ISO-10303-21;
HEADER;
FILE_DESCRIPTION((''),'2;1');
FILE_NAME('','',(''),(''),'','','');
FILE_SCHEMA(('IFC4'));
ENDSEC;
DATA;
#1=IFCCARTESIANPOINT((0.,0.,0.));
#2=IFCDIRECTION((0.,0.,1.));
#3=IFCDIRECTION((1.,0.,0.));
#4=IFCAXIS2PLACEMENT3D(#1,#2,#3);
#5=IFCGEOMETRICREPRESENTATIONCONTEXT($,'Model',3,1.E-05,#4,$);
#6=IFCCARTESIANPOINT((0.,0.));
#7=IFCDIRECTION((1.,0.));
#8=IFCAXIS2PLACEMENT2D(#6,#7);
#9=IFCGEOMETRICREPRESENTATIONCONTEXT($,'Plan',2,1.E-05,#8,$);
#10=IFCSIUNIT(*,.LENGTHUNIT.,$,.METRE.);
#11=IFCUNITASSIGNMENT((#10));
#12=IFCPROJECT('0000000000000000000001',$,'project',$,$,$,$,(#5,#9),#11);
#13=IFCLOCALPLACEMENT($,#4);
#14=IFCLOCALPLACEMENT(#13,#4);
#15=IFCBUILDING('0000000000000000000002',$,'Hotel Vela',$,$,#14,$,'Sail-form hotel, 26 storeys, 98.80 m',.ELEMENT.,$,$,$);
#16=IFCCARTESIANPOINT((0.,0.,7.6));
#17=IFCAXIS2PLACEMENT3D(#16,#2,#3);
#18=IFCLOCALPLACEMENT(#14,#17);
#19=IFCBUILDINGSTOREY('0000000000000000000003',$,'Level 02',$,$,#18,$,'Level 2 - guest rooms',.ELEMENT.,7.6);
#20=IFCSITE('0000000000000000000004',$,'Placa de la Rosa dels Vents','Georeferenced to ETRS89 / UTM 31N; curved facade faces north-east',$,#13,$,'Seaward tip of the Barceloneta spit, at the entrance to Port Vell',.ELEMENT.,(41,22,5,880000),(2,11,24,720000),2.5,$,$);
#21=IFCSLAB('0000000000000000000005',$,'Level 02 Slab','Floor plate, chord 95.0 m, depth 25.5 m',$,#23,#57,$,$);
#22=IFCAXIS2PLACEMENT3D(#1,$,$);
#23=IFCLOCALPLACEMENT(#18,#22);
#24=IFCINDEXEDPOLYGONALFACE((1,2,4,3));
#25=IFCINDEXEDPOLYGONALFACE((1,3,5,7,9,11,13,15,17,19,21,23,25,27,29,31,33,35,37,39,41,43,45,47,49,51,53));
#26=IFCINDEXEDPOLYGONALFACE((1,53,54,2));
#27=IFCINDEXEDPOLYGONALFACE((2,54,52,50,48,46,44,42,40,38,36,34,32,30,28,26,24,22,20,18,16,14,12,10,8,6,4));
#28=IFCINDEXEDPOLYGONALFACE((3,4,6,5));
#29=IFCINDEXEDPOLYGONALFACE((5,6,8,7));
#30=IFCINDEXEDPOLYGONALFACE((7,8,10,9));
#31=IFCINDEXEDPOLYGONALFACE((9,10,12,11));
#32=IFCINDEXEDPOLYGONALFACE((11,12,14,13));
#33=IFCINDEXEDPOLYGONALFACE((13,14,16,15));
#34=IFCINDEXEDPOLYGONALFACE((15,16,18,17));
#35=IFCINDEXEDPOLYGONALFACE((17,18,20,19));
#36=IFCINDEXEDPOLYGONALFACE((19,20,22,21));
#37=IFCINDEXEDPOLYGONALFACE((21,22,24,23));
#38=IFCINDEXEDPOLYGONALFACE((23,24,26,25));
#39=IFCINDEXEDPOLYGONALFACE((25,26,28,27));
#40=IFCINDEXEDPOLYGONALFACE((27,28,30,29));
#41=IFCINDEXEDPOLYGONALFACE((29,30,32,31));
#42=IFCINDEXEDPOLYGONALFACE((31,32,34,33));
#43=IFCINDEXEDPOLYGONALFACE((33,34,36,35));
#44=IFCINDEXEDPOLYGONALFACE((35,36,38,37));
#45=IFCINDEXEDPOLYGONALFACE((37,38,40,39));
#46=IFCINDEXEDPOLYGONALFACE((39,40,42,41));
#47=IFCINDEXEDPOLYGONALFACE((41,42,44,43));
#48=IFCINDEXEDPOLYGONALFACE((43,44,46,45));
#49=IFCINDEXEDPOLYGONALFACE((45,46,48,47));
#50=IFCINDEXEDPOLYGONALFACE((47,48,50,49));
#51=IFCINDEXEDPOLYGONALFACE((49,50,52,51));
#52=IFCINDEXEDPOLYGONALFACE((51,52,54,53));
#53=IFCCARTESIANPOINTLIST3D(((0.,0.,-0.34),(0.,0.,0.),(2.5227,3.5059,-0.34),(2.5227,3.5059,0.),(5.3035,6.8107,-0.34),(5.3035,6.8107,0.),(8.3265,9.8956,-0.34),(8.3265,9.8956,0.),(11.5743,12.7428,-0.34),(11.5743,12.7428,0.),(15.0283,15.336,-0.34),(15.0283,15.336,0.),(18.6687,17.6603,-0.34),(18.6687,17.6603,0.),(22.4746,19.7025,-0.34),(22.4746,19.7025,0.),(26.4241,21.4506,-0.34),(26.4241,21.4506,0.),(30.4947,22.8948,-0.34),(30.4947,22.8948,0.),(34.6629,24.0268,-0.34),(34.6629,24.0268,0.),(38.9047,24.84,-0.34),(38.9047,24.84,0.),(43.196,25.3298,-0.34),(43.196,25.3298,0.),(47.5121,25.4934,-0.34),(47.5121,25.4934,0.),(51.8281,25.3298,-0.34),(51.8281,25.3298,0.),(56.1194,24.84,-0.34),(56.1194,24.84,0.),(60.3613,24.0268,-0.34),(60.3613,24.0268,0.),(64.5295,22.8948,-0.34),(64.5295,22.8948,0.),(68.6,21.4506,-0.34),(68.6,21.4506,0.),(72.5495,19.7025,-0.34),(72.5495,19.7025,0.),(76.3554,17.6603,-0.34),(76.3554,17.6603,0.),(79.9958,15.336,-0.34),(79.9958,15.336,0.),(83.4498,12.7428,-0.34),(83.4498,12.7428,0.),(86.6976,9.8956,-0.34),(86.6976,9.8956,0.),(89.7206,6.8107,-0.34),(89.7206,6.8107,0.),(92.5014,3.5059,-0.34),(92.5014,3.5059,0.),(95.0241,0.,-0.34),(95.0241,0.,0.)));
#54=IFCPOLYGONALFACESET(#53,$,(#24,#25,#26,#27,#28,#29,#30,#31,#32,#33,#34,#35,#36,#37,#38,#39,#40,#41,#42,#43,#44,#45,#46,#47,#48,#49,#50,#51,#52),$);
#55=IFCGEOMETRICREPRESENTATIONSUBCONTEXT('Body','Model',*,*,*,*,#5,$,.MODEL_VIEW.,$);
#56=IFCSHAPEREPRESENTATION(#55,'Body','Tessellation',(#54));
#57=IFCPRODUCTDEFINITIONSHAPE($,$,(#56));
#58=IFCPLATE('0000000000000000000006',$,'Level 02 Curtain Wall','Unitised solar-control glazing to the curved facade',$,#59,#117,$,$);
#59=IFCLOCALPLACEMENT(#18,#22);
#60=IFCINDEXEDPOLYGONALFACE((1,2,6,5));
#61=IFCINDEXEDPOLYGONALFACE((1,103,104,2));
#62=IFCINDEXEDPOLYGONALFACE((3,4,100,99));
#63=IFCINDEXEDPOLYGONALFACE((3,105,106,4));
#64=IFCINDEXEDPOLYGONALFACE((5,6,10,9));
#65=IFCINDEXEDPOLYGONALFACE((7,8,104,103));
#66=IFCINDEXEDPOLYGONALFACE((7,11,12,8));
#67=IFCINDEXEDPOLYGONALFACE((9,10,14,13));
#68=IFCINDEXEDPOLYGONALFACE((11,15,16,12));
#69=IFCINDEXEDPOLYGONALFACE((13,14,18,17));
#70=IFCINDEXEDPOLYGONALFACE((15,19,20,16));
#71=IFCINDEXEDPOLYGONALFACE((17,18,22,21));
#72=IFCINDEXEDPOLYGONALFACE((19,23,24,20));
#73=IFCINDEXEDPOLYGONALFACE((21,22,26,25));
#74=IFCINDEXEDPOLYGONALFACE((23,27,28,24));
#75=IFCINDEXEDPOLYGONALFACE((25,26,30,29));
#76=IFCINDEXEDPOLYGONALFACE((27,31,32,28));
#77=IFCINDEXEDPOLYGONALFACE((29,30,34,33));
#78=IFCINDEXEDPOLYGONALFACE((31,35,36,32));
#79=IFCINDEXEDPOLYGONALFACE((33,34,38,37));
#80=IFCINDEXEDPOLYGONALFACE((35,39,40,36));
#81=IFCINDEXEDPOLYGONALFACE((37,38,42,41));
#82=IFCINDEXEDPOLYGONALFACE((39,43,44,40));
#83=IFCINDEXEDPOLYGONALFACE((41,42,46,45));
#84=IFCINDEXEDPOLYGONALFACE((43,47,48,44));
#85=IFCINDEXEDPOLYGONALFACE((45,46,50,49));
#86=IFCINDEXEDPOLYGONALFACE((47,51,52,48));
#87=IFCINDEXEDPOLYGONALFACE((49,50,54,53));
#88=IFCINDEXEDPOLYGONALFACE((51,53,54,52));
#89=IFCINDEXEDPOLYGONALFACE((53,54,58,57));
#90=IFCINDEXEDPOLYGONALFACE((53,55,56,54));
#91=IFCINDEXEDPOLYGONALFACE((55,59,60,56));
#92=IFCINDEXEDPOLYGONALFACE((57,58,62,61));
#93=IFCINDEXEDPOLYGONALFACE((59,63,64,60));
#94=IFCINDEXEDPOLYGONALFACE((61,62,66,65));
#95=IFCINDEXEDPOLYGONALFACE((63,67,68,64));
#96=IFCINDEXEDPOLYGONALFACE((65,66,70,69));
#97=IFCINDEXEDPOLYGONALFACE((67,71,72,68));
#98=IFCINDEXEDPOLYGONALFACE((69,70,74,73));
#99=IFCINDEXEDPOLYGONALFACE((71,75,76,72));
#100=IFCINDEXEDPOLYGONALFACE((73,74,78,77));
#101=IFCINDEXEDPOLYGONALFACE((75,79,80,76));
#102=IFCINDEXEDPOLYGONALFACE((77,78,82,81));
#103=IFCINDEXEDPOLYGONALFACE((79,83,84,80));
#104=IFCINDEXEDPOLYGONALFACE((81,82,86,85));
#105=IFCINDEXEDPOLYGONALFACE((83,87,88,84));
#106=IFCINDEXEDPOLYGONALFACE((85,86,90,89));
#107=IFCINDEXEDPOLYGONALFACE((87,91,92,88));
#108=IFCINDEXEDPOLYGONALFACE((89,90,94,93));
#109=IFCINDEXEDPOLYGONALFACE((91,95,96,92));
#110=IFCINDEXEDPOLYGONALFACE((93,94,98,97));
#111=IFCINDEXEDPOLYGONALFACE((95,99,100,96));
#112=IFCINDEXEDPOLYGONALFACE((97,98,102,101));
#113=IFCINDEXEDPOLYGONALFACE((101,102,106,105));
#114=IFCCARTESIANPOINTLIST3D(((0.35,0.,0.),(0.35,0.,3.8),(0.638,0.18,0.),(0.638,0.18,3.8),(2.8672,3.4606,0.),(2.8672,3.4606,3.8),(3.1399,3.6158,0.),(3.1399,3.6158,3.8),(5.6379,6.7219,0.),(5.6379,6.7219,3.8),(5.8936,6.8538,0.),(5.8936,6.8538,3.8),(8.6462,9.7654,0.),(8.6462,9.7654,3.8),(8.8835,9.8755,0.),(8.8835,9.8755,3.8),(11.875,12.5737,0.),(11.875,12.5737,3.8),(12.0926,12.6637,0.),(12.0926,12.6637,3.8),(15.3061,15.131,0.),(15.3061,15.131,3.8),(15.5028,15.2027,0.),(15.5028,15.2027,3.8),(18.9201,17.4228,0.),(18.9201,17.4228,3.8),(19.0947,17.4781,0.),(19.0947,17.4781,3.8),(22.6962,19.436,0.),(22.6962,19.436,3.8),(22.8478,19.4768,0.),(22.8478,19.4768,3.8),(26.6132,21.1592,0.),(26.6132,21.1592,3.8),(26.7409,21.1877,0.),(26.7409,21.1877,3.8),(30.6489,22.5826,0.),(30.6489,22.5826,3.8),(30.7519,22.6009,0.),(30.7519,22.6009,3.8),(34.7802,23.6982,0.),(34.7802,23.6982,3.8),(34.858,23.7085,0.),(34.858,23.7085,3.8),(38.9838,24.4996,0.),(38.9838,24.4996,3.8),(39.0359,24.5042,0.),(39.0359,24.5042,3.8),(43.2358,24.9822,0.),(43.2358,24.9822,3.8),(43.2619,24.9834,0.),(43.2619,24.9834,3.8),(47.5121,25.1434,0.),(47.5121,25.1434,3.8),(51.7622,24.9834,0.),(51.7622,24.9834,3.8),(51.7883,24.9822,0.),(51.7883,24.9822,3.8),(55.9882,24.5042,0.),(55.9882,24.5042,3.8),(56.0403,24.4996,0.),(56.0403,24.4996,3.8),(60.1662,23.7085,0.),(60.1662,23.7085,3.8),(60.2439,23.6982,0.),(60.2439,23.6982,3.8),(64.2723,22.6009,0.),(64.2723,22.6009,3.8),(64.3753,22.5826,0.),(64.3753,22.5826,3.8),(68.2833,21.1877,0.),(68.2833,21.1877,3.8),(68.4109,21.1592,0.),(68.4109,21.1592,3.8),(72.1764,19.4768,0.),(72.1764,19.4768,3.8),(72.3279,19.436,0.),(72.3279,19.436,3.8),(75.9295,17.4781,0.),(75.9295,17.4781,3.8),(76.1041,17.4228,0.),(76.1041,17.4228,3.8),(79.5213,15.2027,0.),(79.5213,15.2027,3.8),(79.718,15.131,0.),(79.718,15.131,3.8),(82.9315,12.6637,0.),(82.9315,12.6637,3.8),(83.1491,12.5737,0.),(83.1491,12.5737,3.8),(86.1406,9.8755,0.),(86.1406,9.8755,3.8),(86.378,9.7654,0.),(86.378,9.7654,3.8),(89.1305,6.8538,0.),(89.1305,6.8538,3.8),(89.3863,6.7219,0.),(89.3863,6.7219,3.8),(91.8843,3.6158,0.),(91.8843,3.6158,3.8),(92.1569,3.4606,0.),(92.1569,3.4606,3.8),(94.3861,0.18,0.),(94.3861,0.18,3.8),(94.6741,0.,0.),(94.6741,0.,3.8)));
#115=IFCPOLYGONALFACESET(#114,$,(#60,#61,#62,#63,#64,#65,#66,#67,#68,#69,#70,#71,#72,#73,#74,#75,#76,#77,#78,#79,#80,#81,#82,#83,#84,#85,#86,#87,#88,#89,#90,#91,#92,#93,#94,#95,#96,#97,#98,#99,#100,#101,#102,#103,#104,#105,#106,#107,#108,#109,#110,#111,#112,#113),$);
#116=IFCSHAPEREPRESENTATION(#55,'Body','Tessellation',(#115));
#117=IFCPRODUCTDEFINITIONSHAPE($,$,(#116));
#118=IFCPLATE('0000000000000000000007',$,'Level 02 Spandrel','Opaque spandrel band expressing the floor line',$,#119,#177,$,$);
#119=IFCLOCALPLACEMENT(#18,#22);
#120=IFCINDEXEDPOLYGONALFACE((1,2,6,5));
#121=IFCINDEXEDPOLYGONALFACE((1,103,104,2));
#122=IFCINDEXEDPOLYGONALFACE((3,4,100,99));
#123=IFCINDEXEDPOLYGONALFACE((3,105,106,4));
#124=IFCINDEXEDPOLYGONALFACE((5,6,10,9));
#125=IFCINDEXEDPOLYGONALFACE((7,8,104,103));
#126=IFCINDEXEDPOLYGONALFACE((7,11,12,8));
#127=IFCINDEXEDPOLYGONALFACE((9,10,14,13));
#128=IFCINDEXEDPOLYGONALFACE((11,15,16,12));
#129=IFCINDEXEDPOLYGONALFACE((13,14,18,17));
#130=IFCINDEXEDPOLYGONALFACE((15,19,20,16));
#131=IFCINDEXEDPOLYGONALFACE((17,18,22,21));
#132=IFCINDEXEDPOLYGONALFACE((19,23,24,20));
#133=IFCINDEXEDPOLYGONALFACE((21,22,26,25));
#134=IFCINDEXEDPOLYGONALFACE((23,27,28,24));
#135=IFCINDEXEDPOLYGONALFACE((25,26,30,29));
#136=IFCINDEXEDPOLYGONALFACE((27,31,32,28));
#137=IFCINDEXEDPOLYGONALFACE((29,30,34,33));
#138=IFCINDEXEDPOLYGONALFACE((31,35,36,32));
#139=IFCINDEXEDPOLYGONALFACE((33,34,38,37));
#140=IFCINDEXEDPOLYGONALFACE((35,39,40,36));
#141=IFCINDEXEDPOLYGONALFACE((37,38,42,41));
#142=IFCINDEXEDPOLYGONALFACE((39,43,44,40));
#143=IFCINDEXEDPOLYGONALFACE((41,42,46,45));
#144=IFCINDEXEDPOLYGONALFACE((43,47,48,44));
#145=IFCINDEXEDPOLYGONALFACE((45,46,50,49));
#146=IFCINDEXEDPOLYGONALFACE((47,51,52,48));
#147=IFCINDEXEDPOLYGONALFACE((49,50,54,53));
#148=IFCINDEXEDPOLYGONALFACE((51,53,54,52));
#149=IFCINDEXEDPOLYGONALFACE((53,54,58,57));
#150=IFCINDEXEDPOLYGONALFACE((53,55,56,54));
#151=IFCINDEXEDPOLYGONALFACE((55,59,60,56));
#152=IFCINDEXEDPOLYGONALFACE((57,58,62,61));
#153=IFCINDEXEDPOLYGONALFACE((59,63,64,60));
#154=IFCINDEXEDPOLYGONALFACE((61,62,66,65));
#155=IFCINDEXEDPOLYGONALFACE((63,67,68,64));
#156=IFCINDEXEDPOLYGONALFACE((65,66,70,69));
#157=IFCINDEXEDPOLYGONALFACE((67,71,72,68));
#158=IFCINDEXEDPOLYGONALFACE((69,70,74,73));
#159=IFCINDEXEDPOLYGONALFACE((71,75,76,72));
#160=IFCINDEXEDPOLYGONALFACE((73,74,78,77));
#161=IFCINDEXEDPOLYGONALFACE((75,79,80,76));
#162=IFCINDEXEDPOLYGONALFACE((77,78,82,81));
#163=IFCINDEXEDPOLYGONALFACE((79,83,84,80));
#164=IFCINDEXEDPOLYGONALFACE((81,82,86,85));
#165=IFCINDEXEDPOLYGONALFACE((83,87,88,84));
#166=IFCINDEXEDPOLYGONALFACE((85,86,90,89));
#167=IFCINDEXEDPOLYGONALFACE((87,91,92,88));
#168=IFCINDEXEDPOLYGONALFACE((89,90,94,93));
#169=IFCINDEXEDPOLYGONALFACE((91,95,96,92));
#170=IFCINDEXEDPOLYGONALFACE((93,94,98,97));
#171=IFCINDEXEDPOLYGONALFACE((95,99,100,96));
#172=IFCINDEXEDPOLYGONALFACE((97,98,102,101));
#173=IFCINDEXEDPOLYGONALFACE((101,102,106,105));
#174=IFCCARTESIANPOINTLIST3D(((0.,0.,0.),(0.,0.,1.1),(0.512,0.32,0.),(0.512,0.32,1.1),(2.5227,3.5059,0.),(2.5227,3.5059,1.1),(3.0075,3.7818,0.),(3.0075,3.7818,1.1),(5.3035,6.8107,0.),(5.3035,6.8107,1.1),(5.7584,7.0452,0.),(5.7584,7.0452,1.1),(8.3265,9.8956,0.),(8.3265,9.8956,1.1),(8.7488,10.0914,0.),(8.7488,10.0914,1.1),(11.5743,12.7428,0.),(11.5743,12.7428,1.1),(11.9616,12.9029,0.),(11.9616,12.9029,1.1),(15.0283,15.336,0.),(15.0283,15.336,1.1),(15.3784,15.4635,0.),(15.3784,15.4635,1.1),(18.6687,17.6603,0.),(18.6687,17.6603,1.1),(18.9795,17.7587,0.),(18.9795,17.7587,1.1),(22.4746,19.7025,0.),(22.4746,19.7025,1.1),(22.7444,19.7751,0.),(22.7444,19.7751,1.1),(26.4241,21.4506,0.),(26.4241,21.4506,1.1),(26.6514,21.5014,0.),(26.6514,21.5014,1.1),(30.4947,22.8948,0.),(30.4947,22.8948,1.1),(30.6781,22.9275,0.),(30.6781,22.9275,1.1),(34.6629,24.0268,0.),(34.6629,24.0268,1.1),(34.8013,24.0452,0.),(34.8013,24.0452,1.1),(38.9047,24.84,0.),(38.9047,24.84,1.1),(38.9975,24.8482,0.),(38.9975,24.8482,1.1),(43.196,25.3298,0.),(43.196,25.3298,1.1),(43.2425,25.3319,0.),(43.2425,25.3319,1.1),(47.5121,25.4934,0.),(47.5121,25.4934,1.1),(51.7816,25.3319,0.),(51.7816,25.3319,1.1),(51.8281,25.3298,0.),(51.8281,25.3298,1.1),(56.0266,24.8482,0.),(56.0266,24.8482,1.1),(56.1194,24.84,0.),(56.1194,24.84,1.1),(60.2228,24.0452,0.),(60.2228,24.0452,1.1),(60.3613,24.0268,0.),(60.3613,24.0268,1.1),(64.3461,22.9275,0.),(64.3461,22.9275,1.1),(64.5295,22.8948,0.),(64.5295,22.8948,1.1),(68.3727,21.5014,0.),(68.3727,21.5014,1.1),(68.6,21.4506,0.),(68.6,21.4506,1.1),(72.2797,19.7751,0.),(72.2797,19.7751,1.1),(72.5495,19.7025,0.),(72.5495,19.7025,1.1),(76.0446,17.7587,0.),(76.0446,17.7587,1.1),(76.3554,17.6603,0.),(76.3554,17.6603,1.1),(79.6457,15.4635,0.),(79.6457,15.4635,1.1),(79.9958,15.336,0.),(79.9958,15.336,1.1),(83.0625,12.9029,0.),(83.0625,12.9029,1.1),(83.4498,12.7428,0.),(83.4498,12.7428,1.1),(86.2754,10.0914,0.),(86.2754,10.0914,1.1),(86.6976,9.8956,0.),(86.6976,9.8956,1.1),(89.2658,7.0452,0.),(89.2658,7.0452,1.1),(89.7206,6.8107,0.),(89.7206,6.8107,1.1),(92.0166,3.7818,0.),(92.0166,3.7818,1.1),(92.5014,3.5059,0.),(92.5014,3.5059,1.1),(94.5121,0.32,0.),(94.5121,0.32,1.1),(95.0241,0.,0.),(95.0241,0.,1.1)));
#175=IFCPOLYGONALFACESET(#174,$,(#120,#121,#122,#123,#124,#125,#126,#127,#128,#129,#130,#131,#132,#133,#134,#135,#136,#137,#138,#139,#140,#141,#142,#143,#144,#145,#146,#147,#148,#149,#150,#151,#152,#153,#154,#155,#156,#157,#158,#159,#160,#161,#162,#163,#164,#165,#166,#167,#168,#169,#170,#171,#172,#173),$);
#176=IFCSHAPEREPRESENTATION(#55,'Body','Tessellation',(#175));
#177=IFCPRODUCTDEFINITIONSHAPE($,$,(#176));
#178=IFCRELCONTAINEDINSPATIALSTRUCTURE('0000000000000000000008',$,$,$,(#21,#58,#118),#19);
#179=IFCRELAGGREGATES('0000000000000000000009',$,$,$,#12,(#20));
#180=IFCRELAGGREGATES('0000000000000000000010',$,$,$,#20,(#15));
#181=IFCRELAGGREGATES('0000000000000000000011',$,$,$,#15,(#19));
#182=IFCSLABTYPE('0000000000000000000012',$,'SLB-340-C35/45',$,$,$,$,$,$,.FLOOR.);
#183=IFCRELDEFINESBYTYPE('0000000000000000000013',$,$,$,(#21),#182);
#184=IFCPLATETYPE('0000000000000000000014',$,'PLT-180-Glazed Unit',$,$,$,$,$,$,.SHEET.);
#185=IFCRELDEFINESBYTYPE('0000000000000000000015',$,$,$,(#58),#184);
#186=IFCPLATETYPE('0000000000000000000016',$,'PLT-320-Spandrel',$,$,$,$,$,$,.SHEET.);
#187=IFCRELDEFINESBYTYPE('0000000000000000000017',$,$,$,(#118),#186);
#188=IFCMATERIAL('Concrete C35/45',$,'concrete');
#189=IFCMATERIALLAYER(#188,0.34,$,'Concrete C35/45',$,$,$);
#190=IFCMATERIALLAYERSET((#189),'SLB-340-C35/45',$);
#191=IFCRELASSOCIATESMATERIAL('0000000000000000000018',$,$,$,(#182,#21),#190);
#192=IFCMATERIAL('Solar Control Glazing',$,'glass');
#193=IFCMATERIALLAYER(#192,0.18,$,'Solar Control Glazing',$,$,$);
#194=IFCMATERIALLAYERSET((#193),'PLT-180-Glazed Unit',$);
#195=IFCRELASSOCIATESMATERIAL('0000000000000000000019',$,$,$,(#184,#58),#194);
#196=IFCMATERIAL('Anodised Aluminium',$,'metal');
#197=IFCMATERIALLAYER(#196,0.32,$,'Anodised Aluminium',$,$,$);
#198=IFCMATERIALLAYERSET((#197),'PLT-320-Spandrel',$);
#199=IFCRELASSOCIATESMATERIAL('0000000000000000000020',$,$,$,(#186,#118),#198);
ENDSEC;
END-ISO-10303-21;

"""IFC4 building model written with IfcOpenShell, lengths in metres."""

from ifc_helpers import new_model, si_unit, frame, origin_with_axes, origin_2d_with_axis, place, context, subcontext, project, spatial, line, indexed_curve, outline, extrude, material, layer, layer_set, layer_usage, type_object, element, save


model = new_model("IFC4")

# Units and contexts
model_context = context("Model", 3, precision=1e-05, world=origin_with_axes())
plan_context = context("Plan", 2, precision=1e-05, world=origin_2d_with_axis())
body_context = subcontext(model_context, "Body", "Model", "MODEL_VIEW")
ifc_project = project(units=[si_unit("LENGTHUNIT", "METRE")], contexts=[model_context, plan_context])

# Site, building, storey
site_placement = place(None, origin_with_axes())
site = spatial("IfcSite", under=ifc_project, at=site_placement, Name="Placa de la Rosa dels Vents", Description="Georeferenced to ETRS89 / UTM 31N; curved facade faces north-east", LongName="Seaward tip of the Barceloneta spit, at the entrance to Port Vell", CompositionType="ELEMENT", RefLatitude=(41, 22, 5, 880000), RefLongitude=(2, 11, 24, 720000), RefElevation=2.5)
building_placement = place(site_placement, origin_with_axes())
building = spatial("IfcBuilding", under=site, at=building_placement, Name="Hotel Vela", LongName="Sail-form hotel, 26 storeys, 98.80 m", CompositionType="ELEMENT")
storey_placement = place(building_placement, frame((0.0, 0.0, 7.6), z_axis=(0.0, 0.0, 1.0), x_axis=(1.0, 0.0, 0.0)))
storey = spatial("IfcBuildingStorey", under=building, at=storey_placement, Name="Level 02", LongName="Level 2 - guest rooms", CompositionType="ELEMENT", Elevation=7.6)

# Slab
ifc_material_1 = material(Name="Concrete C35/45", Category="concrete")
ifc_layer_1 = layer(ifc_material_1, 0.34, Name="Concrete C35/45")
ifc_layer_set_1 = layer_set([ifc_layer_1], Name="SLB-340-C35/45")
ifc_layer_usage_1 = layer_usage(ifc_layer_set_1, "AXIS3", "POSITIVE", 0.0)
slab_type = type_object("IfcSlabType", Name="SLB-340-C35/45", PredefinedType="FLOOR", material=ifc_layer_set_1)
slab_placement = place(storey_placement, frame((0.0, 0.0, -0.34), z_axis=(0.0, 0.0, 1.0), x_axis=(1.0, 0.0, 0.0)))
element("IfcSlab", 1, at=slab_placement, inside=storey, type_object=slab_type, material=ifc_layer_usage_1, Name="Level 02 Slab", Description="Floor plate, chord 95.0 m, depth 25.5 m", context=body_context, shape_type="SweptSolid", body=[
    extrude(outline(indexed_curve([(0.0, 0.0), (95.0241, 0.0), (92.5014, 3.5059), (89.7206, 6.8107), (86.6976, 9.8956), (83.4498, 12.7428), (79.9958, 15.336), (76.3554, 17.6603), (72.5495, 19.7025), (68.6, 21.4506), (64.5295, 22.8948), (60.3613, 24.0268), (56.1194, 24.84), (51.8281, 25.3298), (47.5121, 25.4934), (43.196, 25.3298), (38.9047, 24.84), (34.6629, 24.0268), (30.4947, 22.8948), (26.4241, 21.4506), (22.4746, 19.7025), (18.6687, 17.6603), (15.0283, 15.336), (11.5743, 12.7428), (8.3265, 9.8956), (5.3035, 6.8107), (2.5227, 3.5059)], segments=[line(1, 2, 3, 4, 5, 6, 7, 8, 9, 10, 11, 12, 13, 14, 15, 16, 17, 18, 19, 20, 21, 22, 23, 24, 25, 26, 27, 1)])), origin_with_axes(), (0.0, 0.0, 1.0), 0.34),
])

# Plates
ifc_material_2 = material(Name="Solar Control Glazing", Category="glass")
ifc_layer_2 = layer(ifc_material_2, 0.18, Name="Solar Control Glazing")
ifc_layer_set_2 = layer_set([ifc_layer_2], Name="PLT-180-Glazed Unit")
ifc_layer_usage_2 = layer_usage(ifc_layer_set_2, "AXIS2", "POSITIVE", 0.0)
plate_type_1 = type_object("IfcPlateType", Name="PLT-180-Glazed Unit", PredefinedType="SHEET", material=ifc_layer_set_2)
plate_1_placement = place(storey_placement, frame((0.35, 0.0, 0.0), z_axis=(0.0, 0.0, 1.0), x_axis=(1.0, 0.0, 0.0)))
element("IfcPlate", 2, at=plate_1_placement, inside=storey, type_object=plate_type_1, material=ifc_layer_usage_2, Name="Level 02 Curtain Wall", Description="Unitised solar-control glazing to the curved facade", context=body_context, shape_type="SweptSolid", body=[
    extrude(outline(indexed_curve([(94.3241, 0.0), (91.8069, 3.4606), (89.0363, 6.7219), (86.028, 9.7654), (82.7991, 12.5737), (79.368, 15.131), (75.7541, 17.4228), (71.9779, 19.436), (68.0609, 21.1592), (64.0253, 22.5826), (59.8939, 23.6982), (55.6903, 24.4996), (51.4383, 24.9822), (47.1621, 25.1434), (42.8858, 24.9822), (38.6338, 24.4996), (34.4302, 23.6982), (30.2989, 22.5826), (26.2632, 21.1592), (22.3462, 19.436), (18.5701, 17.4228), (14.9561, 15.131), (11.525, 12.5737), (8.2962, 9.7654), (5.2879, 6.7219), (2.5172, 3.4606), (0.0, 0.0), (94.0361, 0.18), (2.7899, 3.6158), (5.5436, 6.8538), (8.5335, 9.8755), (11.7426, 12.6637), (15.1528, 15.2027), (18.7447, 17.4781), (22.4978, 19.4768), (26.3909, 21.1877), (30.4019, 22.6009), (34.508, 23.7085), (38.6859, 24.5042), (42.9119, 24.9834), (47.1621, 25.1434), (51.4122, 24.9834), (55.6382, 24.5042), (59.8162, 23.7085), (63.9223, 22.6009), (67.9333, 21.1877), (71.8264, 19.4768), (75.5795, 17.4781), (79.1713, 15.2027), (82.5815, 12.6637), (85.7906, 9.8755), (88.7805, 6.8538), (91.5343, 3.6158), (0.288, 0.18)], segments=[line(1, 2, 3, 4, 5, 6, 7, 8, 9, 10, 11, 12, 13, 14, 15, 16, 17, 18, 19, 20, 21, 22, 23, 24, 25, 26, 27, 28, 29, 30, 31, 32, 33, 34, 35, 36, 37, 38, 39, 40, 41, 42, 43, 44, 45, 46, 47, 48, 49, 50, 51, 52, 53, 54, 1)])), origin_with_axes(), (0.0, 0.0, 1.0), 3.8),
])
ifc_material_3 = material(Name="Anodised Aluminium", Category="metal")
ifc_layer_3 = layer(ifc_material_3, 0.32, Name="Anodised Aluminium")
ifc_layer_set_3 = layer_set([ifc_layer_3], Name="PLT-320-Spandrel")
ifc_layer_usage_3 = layer_usage(ifc_layer_set_3, "AXIS2", "POSITIVE", 0.0)
plate_type_2 = type_object("IfcPlateType", Name="PLT-320-Spandrel", PredefinedType="SHEET", material=ifc_layer_set_3)
plate_2_placement = place(storey_placement, origin_with_axes())
element("IfcPlate", 3, at=plate_2_placement, inside=storey, type_object=plate_type_2, material=ifc_layer_usage_3, Name="Level 02 Spandrel", Description="Opaque spandrel band expressing the floor line", context=body_context, shape_type="SweptSolid", body=[
    extrude(outline(indexed_curve([(95.0241, 0.0), (92.5014, 3.5059), (89.7206, 6.8107), (86.6976, 9.8956), (83.4498, 12.7428), (79.9958, 15.336), (76.3554, 17.6603), (72.5495, 19.7025), (68.6, 21.4506), (64.5295, 22.8948), (60.3613, 24.0268), (56.1194, 24.84), (51.8281, 25.3298), (47.5121, 25.4934), (43.196, 25.3298), (38.9047, 24.84), (34.6629, 24.0268), (30.4947, 22.8948), (26.4241, 21.4506), (22.4746, 19.7025), (18.6687, 17.6603), (15.0283, 15.336), (11.5743, 12.7428), (8.3265, 9.8956), (5.3035, 6.8107), (2.5227, 3.5059), (0.0, 0.0), (94.5121, 0.32), (3.0075, 3.7818), (5.7584, 7.0452), (8.7488, 10.0914), (11.9616, 12.9029), (15.3784, 15.4635), (18.9795, 17.7587), (22.7444, 19.7751), (26.6514, 21.5014), (30.6781, 22.9275), (34.8013, 24.0452), (38.9975, 24.8482), (43.2425, 25.3319), (47.5121, 25.4934), (51.7816, 25.3319), (56.0266, 24.8482), (60.2228, 24.0452), (64.3461, 22.9275), (68.3727, 21.5014), (72.2797, 19.7751), (76.0446, 17.7587), (79.6457, 15.4635), (83.0625, 12.9029), (86.2754, 10.0914), (89.2658, 7.0452), (92.0166, 3.7818), (0.512, 0.32)], segments=[line(1, 2, 3, 4, 5, 6, 7, 8, 9, 10, 11, 12, 13, 14, 15, 16, 17, 18, 19, 20, 21, 22, 23, 24, 25, 26, 27, 28, 29, 30, 31, 32, 33, 34, 35, 36, 37, 38, 39, 40, 41, 42, 43, 44, 45, 46, 47, 48, 49, 50, 51, 52, 53, 54, 1)])), origin_with_axes(), (0.0, 0.0, 1.0), 1.1),
])

save(model, "model.ifc")
